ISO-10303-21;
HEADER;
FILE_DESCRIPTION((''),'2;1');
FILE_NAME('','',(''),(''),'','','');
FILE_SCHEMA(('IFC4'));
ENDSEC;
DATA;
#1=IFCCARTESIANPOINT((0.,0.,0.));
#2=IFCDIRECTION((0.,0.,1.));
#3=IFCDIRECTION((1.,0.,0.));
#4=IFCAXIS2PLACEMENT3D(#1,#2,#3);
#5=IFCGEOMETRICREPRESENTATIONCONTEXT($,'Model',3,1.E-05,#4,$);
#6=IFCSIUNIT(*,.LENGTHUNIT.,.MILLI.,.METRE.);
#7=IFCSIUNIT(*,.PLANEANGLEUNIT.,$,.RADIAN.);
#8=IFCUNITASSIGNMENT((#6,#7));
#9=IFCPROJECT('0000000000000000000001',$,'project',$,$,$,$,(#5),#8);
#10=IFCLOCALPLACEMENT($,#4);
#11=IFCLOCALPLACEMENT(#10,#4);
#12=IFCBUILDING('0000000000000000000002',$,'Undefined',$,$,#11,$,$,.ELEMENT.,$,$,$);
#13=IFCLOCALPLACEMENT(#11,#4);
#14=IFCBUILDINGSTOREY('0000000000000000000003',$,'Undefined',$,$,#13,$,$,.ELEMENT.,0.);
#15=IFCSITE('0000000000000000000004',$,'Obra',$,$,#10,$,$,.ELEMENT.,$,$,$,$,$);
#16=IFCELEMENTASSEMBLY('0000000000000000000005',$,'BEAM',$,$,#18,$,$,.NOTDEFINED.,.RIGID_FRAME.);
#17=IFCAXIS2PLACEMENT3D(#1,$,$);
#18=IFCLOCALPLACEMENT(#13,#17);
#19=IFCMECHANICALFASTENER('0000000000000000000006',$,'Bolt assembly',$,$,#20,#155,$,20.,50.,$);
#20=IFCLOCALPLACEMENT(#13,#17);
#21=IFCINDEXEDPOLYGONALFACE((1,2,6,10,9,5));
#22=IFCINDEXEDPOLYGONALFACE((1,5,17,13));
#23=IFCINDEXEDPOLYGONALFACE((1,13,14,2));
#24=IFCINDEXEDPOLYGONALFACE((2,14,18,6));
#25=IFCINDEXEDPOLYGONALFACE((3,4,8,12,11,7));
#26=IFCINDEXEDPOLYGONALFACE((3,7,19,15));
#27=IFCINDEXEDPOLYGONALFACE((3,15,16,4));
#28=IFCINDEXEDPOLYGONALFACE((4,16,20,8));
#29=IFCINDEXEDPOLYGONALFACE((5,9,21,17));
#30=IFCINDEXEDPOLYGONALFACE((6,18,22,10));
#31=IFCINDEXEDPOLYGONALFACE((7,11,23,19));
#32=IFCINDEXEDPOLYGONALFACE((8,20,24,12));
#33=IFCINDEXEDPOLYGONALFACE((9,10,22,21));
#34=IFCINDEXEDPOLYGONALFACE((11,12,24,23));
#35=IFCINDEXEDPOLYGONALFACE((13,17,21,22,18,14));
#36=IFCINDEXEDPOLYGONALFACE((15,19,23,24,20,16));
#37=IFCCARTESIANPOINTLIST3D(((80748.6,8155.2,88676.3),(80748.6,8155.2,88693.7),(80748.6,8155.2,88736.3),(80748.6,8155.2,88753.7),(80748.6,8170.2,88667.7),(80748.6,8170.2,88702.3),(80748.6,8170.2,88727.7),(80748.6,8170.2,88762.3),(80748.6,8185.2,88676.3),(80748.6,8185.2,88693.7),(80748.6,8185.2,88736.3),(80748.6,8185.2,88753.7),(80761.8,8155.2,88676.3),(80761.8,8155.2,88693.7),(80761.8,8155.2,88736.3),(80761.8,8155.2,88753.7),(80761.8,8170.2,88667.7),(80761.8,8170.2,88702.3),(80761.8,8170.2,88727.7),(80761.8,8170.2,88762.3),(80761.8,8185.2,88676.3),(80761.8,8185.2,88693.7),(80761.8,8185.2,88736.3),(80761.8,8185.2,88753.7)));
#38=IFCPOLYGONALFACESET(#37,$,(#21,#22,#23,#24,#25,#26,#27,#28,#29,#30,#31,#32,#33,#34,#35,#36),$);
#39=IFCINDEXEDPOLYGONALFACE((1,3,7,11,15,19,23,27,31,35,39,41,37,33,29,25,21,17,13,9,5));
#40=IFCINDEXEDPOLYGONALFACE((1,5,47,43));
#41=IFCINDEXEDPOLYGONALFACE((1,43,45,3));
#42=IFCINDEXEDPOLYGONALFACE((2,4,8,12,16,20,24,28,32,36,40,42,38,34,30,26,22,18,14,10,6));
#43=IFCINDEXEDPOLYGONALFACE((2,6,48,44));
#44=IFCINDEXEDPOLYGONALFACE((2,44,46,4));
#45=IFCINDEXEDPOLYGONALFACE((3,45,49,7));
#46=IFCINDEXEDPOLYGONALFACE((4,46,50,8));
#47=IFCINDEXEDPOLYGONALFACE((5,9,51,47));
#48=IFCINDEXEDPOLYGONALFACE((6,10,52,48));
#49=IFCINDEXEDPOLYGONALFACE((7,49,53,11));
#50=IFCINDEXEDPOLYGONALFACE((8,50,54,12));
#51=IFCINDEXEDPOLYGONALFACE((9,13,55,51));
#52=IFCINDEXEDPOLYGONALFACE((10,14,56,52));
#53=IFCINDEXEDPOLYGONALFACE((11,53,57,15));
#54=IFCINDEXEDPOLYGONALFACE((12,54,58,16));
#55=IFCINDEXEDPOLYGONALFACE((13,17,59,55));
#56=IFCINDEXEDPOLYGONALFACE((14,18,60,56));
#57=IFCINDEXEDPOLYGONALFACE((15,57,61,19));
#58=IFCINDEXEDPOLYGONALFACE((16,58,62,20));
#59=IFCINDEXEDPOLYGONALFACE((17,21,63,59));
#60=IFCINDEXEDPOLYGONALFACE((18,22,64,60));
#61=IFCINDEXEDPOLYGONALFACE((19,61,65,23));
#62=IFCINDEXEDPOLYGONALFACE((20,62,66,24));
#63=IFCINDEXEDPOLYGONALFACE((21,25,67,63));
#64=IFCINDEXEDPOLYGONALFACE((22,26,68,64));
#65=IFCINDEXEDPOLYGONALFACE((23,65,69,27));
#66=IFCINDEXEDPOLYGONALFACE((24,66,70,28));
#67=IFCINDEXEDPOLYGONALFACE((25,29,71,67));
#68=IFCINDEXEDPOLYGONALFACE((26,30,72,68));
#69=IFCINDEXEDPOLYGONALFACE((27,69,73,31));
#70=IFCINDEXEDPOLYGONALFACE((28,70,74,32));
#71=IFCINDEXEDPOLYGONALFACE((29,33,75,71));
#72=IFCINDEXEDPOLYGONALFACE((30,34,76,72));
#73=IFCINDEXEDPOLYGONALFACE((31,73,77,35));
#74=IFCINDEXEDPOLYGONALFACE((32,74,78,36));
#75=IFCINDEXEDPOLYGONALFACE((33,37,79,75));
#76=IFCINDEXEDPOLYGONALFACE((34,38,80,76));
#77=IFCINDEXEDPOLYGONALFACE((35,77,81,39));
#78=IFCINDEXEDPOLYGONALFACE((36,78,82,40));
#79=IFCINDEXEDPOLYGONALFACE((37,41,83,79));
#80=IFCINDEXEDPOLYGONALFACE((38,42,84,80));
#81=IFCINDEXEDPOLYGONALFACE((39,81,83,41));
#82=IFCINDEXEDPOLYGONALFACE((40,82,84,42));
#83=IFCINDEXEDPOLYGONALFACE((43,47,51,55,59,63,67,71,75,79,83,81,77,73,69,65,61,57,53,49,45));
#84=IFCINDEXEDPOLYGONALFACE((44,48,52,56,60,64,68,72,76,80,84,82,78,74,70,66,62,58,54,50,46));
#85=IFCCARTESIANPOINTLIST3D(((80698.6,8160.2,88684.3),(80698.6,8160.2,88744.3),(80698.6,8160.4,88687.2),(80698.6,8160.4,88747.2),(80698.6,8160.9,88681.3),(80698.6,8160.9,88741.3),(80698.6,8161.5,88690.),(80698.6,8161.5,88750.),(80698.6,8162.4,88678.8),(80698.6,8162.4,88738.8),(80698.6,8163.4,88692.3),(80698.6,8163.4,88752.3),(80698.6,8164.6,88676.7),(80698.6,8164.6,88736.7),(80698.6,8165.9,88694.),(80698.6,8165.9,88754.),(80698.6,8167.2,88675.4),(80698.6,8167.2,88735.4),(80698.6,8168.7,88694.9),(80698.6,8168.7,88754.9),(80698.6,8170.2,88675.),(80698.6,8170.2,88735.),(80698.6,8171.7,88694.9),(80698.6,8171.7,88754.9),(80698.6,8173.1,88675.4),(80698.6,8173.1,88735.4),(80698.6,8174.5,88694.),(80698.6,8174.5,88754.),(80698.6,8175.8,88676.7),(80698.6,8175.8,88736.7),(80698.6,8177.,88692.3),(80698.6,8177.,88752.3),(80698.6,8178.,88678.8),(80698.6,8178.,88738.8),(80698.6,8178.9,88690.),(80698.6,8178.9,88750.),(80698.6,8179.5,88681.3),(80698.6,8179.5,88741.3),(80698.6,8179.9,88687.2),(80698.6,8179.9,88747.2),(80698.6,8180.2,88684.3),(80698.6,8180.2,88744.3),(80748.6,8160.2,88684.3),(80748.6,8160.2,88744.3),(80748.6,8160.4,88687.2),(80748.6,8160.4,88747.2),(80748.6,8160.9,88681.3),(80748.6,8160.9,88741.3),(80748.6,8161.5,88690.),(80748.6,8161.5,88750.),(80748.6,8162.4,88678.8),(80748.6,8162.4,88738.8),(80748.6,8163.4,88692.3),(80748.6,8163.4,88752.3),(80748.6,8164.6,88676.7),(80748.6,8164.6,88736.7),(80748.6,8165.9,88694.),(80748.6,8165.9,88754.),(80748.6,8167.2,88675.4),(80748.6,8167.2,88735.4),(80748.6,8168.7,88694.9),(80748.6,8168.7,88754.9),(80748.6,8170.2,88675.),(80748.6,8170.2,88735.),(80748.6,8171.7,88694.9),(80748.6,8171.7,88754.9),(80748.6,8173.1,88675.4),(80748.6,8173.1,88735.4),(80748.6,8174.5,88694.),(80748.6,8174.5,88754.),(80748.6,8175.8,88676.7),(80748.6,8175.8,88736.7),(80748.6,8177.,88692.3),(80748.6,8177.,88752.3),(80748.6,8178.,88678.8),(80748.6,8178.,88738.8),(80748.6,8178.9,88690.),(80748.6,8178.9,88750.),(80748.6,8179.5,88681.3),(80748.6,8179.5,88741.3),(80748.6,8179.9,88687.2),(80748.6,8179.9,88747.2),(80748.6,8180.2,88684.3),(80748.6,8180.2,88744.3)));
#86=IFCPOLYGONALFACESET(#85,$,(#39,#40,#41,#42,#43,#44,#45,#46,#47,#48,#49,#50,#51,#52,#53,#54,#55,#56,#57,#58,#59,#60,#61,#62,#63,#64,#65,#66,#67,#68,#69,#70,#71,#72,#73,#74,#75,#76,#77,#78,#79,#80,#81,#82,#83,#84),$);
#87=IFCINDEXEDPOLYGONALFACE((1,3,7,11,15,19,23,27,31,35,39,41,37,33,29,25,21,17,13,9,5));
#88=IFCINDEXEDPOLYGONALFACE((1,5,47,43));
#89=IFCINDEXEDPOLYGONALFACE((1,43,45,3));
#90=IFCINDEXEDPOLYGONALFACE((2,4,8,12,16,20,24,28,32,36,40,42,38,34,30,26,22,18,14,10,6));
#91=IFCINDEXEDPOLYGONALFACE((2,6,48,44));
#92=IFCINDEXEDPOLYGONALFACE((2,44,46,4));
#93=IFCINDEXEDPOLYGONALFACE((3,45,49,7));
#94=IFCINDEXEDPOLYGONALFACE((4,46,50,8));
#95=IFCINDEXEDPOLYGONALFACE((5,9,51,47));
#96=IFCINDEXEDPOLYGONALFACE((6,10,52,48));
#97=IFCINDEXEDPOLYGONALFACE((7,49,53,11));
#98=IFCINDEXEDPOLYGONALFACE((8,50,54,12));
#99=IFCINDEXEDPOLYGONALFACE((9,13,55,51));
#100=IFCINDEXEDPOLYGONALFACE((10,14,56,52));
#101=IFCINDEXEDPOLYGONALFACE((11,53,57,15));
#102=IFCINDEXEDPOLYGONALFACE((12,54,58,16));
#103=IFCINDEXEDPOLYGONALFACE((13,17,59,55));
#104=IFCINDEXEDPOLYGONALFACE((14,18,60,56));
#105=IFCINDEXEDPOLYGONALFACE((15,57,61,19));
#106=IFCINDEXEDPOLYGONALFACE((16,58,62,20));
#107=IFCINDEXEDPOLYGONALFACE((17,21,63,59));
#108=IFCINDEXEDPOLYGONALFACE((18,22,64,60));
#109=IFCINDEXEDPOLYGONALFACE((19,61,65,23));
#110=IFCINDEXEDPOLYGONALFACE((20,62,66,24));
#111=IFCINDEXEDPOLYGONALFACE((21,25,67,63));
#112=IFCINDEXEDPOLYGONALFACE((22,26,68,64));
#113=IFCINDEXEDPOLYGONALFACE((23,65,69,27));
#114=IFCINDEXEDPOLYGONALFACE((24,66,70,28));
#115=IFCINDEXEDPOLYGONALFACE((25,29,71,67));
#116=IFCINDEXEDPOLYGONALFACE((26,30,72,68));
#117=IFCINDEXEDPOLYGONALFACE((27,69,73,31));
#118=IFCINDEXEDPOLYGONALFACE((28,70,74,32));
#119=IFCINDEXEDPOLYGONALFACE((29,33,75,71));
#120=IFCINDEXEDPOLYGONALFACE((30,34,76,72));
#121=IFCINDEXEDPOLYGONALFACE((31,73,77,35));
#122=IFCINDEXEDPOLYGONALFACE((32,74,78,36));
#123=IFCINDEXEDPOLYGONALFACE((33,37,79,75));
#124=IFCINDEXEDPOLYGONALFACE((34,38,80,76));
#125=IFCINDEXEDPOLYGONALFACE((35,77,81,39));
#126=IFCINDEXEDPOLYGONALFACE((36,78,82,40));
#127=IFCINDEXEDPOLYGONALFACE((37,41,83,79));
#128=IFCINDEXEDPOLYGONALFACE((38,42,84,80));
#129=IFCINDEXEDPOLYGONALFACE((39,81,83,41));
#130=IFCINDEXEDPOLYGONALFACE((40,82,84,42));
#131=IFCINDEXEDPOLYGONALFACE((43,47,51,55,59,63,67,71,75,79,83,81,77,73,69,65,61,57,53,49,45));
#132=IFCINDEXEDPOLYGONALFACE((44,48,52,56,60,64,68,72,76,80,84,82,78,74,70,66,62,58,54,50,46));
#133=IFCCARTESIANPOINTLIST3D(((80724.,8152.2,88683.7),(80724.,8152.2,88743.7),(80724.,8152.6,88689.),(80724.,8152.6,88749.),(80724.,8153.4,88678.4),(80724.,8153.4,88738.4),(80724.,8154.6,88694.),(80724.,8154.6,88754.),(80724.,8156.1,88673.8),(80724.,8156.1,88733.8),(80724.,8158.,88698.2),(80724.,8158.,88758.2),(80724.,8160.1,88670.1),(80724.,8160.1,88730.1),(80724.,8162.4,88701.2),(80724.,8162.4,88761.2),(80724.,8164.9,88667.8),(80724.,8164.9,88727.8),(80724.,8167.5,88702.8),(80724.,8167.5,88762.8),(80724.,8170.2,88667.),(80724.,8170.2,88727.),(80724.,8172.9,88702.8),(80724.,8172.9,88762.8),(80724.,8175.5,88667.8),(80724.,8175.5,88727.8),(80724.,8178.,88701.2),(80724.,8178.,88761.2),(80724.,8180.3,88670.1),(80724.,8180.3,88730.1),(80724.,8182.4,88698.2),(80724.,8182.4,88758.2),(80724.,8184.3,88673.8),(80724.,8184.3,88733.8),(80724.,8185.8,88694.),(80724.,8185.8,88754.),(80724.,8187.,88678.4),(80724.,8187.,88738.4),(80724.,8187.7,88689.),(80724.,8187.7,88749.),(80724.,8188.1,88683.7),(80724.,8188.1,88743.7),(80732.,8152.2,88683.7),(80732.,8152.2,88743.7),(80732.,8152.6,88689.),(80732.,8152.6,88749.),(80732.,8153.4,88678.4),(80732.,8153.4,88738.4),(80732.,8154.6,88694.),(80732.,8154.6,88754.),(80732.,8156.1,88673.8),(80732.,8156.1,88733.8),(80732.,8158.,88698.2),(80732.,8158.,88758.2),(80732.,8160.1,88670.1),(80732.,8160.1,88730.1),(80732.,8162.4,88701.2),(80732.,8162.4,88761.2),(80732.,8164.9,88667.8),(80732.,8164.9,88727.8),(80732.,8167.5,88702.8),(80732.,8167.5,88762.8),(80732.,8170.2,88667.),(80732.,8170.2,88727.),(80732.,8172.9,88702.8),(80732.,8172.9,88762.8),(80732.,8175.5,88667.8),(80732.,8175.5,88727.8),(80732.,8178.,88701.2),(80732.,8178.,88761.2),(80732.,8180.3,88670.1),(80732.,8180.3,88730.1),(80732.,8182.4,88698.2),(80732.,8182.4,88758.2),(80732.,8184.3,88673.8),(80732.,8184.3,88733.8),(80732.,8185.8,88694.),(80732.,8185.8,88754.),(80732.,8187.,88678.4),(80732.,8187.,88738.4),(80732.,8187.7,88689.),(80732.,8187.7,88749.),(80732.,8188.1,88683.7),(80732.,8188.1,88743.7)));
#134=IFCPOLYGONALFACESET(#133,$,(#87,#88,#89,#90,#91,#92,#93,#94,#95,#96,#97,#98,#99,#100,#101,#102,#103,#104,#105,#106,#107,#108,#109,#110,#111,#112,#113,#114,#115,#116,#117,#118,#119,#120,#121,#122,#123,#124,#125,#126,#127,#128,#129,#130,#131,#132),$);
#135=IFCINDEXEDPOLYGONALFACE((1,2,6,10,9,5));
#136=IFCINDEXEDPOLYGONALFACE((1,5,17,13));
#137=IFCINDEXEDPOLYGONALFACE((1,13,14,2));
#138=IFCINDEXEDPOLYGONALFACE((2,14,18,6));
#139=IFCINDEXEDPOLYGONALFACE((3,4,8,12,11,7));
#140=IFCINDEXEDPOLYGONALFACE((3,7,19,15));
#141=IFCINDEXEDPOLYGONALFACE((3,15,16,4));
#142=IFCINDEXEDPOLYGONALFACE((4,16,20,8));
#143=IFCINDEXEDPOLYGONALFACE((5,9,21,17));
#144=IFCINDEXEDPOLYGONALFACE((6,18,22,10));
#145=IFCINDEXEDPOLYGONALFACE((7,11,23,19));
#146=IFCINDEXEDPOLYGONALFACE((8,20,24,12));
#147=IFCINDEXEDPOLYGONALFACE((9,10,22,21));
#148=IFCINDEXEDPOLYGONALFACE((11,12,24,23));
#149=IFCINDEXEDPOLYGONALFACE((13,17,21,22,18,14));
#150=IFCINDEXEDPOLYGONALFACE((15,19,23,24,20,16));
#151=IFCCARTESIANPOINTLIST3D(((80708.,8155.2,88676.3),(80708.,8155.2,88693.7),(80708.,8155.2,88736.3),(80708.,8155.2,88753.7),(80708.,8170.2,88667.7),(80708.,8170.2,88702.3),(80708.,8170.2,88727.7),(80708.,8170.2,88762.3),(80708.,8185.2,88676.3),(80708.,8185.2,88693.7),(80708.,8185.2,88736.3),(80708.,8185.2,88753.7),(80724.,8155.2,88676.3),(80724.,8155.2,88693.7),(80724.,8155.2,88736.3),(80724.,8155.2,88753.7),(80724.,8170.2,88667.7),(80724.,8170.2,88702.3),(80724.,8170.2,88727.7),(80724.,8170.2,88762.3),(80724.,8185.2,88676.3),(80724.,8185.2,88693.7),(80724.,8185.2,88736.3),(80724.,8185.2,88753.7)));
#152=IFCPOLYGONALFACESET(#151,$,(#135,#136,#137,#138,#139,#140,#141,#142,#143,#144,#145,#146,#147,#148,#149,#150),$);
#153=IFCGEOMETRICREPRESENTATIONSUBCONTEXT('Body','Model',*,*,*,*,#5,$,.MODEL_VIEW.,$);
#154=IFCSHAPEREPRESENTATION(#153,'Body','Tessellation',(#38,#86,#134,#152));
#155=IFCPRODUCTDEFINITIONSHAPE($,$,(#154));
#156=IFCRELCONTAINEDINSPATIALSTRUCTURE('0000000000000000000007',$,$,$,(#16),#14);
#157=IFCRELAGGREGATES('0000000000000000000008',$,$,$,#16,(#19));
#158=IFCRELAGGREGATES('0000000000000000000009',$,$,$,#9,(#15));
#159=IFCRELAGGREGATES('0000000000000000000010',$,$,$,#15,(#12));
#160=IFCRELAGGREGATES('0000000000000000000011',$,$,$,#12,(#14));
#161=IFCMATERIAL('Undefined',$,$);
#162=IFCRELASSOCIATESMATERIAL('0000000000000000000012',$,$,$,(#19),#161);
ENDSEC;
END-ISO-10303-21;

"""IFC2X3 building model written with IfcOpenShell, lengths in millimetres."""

from ifc_helpers import new_model, si_unit, frame, origin_with_axes, origin_2d_with_axis, place, context, subcontext, project, spatial, polyline, circle, outline, extrude, source, transform, mapped, material, element, aggregate, save


model = new_model("IFC2X3")

# Units and contexts
model_context = context("Model", 3, precision=1e-05, world=origin_with_axes())
body_context = subcontext(model_context, "Body", "Model", "MODEL_VIEW")
ifc_project = project(units=[si_unit("LENGTHUNIT", "METRE", prefix="MILLI"), si_unit("PLANEANGLEUNIT", "RADIAN")], contexts=[model_context])

# Site, building, storey
site_placement = place(None, origin_with_axes())
site = spatial("IfcSite", under=ifc_project, at=site_placement, Name="Obra", CompositionType="ELEMENT")
building_placement = place(site_placement, origin_with_axes())
building = spatial("IfcBuilding", under=site, at=building_placement, Name="Undefined", CompositionType="ELEMENT")
storey_placement = place(building_placement, origin_with_axes())
storey = spatial("IfcBuildingStorey", under=building, at=storey_placement, Name="Undefined", CompositionType="ELEMENT", Elevation=0.0)

# Shared definitions
ifc_material_1 = material(Name="Undefined")

# Element assembly, mechanical fastener
shared_shape_1 = source(origin_with_axes(), body_context, "Body", "SweptSolid", [
    extrude(outline(polyline([(17.3, 0.0), (8.7, 15.0), (-8.7, 15.0), (-17.3, 0.0), (-8.7, -15.0), (8.7, -15.0), (17.3, 0.0)])), frame((0.0, -26.5, 0.0), z_axis=(0.0, 1.0, 0.0), x_axis=(1.0, 0.0, 0.0)), (0.0, 0.0, 1.0), 13.2),
    extrude(circle(Radius=10.0, at=origin_2d_with_axis()), frame((0.0, -13.3, 0.0), z_axis=(0.0, 1.0, 0.0), x_axis=(1.0, 0.0, 0.0)), (0.0, 0.0, 1.0), 50.0),
    extrude(circle(Radius=18.0, at=origin_2d_with_axis()), frame((0.0, 3.3, 0.0), z_axis=(0.0, 1.0, 0.0), x_axis=(1.0, 0.0, 0.0)), (0.0, 0.0, 1.0), 8.0),
    extrude(outline(polyline([(17.3, 0.0), (8.7, 15.0), (-8.7, 15.0), (-17.3, 0.0), (-8.7, -15.0), (8.7, -15.0), (17.3, 0.0)])), frame((0.0, 11.3, 0.0), z_axis=(0.0, 1.0, 0.0), x_axis=(1.0, 0.0, 0.0)), (0.0, 0.0, 1.0), 16.0),
])
assembly_1_placement = place(storey_placement, origin_with_axes())
assembly_1 = element("IfcElementAssembly", 1, at=assembly_1_placement, inside=storey, Name="BEAM", AssemblyPlace="NOTDEFINED", PredefinedType="RIGID_FRAME")
mechanical_fastener_1_placement = place(assembly_1_placement, frame((80735.3, 8130.2, 88850.0), z_axis=(0.0, 1.0, 0.0), x_axis=(0.0, 0.0, -1.0)))
mechanical_fastener_1 = element("IfcMechanicalFastener", 2, at=mechanical_fastener_1_placement, material=ifc_material_1, Name="Bolt assembly", NominalDiameter=20.0, NominalLength=50.0, context=body_context, shape_type="MappedRepresentation", body=[
    mapped(shared_shape_1, transform((105.0, 0.0, 40.0))),
    mapped(shared_shape_1, transform((165.0, 0.0, 40.0))),
])
aggregate(assembly_1, [mechanical_fastener_1])

save(model, "model.ifc")
